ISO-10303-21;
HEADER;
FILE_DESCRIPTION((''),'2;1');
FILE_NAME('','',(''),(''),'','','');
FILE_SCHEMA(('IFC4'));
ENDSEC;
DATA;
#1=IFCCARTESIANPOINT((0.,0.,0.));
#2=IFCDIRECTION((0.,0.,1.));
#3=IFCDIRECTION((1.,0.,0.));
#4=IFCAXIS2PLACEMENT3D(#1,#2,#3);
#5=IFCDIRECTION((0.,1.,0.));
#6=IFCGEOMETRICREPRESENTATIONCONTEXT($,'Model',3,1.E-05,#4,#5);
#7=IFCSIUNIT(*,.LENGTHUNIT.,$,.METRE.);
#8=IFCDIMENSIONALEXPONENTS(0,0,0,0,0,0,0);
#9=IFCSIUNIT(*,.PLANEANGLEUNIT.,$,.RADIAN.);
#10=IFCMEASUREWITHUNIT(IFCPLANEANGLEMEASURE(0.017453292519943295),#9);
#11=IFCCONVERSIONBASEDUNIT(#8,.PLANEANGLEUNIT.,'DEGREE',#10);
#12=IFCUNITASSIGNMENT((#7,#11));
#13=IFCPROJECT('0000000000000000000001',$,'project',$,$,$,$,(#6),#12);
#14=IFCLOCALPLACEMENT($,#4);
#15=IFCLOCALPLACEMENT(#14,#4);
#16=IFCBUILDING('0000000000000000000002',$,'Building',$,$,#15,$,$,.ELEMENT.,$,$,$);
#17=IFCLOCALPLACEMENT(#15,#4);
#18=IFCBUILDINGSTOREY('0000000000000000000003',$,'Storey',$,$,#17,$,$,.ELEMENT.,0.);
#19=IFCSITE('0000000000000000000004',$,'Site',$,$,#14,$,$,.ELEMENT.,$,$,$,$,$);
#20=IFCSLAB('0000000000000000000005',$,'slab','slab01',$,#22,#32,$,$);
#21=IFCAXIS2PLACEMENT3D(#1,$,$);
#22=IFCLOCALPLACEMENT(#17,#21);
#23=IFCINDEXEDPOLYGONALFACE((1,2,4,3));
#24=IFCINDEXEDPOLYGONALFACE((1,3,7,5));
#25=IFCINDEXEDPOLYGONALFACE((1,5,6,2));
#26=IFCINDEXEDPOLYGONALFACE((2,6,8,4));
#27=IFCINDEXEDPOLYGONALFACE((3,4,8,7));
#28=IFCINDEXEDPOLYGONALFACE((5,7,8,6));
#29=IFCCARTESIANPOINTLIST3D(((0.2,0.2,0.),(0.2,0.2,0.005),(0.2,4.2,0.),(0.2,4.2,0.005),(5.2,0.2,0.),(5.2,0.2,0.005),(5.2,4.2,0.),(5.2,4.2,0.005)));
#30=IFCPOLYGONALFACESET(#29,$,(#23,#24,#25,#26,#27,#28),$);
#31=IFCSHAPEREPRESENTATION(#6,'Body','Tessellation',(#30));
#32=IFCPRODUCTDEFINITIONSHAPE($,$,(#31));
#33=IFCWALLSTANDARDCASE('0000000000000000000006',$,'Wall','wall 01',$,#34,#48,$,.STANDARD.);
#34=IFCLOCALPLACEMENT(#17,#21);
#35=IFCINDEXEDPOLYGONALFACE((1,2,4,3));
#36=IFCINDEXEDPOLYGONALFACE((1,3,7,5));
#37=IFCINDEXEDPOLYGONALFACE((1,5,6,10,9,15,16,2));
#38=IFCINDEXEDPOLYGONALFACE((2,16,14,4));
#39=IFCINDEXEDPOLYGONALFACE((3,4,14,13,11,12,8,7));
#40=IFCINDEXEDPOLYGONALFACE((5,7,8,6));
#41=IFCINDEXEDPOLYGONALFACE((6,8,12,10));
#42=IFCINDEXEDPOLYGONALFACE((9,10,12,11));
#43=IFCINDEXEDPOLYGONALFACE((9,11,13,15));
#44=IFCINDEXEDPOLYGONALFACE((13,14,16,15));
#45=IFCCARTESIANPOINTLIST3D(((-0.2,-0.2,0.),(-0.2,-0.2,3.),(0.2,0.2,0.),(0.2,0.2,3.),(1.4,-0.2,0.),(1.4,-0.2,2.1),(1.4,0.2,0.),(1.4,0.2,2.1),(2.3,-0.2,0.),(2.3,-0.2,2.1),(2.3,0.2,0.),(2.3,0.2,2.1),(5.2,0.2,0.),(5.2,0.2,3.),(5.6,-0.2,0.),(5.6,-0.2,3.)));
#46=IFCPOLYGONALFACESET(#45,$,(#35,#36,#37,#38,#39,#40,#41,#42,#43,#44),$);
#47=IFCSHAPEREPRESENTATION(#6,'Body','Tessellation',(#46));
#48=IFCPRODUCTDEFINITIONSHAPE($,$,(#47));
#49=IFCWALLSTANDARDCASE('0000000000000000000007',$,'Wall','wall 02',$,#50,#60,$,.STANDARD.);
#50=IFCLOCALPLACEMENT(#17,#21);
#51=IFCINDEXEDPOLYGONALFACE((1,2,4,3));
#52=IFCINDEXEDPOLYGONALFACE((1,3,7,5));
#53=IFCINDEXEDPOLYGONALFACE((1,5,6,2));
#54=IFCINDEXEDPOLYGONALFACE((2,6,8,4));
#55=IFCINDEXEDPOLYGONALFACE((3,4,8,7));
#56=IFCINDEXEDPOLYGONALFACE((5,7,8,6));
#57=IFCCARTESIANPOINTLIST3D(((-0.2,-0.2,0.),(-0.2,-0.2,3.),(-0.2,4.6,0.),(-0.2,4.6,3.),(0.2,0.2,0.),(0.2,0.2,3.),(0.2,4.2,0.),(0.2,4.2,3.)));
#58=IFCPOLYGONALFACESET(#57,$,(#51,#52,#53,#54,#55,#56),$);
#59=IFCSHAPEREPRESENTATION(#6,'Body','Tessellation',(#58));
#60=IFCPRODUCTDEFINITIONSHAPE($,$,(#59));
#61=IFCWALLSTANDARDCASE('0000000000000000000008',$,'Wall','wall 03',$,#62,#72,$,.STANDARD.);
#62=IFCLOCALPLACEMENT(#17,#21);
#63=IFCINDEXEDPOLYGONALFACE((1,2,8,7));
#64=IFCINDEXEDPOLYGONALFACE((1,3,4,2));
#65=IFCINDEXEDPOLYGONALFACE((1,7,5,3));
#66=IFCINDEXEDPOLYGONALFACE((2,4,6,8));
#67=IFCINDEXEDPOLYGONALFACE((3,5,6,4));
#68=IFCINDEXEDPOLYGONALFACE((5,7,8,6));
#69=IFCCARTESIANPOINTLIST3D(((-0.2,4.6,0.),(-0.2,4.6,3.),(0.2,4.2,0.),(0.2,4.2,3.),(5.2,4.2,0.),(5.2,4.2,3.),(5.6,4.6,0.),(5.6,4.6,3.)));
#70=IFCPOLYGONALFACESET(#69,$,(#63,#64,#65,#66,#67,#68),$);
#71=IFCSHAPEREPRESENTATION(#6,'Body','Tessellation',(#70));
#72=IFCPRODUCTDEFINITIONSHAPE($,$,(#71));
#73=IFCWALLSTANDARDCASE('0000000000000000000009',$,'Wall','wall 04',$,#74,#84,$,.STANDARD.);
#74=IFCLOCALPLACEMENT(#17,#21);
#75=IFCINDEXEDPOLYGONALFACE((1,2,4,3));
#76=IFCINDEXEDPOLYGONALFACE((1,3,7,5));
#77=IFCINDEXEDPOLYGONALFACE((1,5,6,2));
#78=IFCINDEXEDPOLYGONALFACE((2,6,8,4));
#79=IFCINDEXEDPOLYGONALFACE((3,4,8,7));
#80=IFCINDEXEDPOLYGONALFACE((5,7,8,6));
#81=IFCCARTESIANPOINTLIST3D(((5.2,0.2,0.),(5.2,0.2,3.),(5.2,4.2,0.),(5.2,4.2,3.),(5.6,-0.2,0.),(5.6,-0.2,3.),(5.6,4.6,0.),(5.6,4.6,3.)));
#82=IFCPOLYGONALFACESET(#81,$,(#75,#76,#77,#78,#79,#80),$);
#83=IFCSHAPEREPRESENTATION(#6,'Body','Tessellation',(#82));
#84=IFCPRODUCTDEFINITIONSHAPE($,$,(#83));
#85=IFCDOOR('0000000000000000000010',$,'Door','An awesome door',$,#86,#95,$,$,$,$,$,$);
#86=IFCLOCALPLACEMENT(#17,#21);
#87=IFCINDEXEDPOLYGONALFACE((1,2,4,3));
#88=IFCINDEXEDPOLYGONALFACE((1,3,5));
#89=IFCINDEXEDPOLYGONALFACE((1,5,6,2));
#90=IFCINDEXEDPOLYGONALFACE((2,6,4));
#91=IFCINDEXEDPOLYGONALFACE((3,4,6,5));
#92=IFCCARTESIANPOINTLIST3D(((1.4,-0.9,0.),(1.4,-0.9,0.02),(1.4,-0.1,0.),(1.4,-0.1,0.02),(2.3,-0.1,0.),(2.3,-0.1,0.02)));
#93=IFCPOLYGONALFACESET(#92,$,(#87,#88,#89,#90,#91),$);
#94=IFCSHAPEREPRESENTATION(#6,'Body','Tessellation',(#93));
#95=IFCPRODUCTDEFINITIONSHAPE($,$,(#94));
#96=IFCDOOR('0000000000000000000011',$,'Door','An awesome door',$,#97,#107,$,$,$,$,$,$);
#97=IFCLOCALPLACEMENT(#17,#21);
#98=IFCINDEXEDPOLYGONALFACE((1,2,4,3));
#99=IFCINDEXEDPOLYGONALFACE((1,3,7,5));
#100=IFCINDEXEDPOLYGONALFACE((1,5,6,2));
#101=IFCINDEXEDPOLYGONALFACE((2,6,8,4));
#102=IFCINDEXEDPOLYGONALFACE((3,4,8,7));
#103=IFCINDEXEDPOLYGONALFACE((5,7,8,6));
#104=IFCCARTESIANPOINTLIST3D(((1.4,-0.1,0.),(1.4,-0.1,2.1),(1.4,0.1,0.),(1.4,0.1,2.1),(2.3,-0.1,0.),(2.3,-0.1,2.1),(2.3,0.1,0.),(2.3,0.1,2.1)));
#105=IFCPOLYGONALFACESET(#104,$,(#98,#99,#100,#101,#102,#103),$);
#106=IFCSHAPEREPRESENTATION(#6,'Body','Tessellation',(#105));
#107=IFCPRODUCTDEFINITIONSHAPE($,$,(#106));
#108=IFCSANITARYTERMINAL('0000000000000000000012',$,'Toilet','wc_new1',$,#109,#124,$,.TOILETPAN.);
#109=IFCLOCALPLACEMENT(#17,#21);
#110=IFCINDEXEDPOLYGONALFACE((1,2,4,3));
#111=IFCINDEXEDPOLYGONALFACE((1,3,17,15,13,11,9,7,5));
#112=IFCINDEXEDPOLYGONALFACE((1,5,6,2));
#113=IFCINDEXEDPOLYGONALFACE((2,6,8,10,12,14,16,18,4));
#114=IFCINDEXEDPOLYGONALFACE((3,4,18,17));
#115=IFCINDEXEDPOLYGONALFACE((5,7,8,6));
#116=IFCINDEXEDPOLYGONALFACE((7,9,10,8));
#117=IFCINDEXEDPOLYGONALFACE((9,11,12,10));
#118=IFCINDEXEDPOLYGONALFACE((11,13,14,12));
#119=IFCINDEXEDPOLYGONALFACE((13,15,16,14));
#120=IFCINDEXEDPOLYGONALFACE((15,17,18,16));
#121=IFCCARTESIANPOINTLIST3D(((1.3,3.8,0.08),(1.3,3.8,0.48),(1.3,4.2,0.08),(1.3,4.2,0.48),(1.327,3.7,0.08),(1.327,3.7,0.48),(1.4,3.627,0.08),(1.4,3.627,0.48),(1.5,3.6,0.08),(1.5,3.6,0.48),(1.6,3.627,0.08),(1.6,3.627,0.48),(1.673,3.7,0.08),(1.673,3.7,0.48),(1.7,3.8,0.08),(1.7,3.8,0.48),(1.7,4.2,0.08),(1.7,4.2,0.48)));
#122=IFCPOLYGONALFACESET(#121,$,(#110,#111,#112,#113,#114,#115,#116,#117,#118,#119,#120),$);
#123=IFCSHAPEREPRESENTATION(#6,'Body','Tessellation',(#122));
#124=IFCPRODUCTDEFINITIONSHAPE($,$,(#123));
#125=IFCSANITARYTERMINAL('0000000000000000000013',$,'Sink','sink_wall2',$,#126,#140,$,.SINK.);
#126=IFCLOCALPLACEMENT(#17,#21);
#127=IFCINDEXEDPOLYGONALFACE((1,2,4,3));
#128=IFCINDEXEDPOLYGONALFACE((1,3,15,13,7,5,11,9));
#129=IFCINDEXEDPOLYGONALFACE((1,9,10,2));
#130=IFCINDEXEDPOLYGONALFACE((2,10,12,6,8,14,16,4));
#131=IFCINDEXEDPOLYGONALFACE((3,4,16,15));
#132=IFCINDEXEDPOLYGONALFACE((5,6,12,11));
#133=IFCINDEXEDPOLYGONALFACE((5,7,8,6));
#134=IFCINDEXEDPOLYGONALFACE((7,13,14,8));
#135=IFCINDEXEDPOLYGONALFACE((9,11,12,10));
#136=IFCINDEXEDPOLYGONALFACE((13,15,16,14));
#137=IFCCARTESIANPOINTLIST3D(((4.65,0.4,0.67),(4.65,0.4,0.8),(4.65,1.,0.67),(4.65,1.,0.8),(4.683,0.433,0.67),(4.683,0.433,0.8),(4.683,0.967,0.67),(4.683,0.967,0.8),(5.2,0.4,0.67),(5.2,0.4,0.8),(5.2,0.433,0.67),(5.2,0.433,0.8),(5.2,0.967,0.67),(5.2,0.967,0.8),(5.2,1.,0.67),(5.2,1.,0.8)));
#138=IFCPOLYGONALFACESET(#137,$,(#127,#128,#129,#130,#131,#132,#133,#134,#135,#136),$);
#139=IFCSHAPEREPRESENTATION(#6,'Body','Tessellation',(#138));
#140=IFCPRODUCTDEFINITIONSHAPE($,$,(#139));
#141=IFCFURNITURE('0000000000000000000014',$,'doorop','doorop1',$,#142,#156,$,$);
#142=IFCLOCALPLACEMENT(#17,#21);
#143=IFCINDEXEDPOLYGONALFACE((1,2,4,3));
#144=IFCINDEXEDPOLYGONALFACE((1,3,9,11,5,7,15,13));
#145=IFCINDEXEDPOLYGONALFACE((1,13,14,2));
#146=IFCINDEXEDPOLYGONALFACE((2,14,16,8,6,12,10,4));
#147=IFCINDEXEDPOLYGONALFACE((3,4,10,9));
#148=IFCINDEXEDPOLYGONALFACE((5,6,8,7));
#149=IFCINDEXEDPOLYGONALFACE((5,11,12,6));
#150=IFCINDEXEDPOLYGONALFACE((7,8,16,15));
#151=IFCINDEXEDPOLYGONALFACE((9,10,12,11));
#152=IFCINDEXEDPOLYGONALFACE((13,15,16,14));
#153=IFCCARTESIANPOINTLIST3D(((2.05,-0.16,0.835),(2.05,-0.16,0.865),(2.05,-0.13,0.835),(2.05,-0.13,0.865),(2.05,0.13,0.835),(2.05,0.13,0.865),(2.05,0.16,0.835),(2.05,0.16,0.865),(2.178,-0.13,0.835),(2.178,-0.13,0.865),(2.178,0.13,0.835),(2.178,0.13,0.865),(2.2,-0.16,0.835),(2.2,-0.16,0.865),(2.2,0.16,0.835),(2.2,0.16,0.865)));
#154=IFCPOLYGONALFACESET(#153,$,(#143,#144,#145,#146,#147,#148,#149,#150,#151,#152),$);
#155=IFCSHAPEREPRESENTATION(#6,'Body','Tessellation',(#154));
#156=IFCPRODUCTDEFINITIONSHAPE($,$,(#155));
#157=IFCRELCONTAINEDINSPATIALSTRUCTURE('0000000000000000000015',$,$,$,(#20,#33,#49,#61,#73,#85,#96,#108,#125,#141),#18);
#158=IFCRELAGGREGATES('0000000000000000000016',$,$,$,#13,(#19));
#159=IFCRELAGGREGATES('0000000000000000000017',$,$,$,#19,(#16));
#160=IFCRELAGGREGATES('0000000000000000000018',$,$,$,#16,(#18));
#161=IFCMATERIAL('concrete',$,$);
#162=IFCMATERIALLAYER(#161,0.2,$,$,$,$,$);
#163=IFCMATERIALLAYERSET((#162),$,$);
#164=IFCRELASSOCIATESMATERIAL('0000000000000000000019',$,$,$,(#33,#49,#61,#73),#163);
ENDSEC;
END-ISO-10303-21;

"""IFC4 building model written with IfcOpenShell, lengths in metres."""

from ifc_helpers import new_model, entity, si_unit, converted_unit, direction, frame, origin_with_axes, place, context, project, spatial, polyline, outline, extrude, material, layer, layer_set, layer_usage, element, save


model = new_model("IFC4")

# Units and contexts
model_context = context("Model", 3, precision=1e-05, world=origin_with_axes(), true_north=direction((0.0, 1.0, 0.0)))
ifc_project = project(units=[si_unit("LENGTHUNIT", "METRE"), converted_unit("PLANEANGLEUNIT", "DEGREE", entity("IfcPlaneAngleMeasure", 0.017453292519943295), si_unit("PLANEANGLEUNIT", "RADIAN"), dimensions=[0, 0, 0, 0, 0, 0, 0])], contexts=[model_context])

# Site, building, storey
site_placement = place(None, origin_with_axes())
site = spatial("IfcSite", under=ifc_project, at=site_placement, Name="Site", CompositionType="ELEMENT")
building_placement = place(site_placement, origin_with_axes())
building = spatial("IfcBuilding", under=site, at=building_placement, Name="Building", CompositionType="ELEMENT")
storey_placement = place(building_placement, origin_with_axes())
storey = spatial("IfcBuildingStorey", under=building, at=storey_placement, Name="Storey", CompositionType="ELEMENT", Elevation=0.0)

# Slab
slab_placement = place(storey_placement, origin_with_axes())
element("IfcSlab", 1, at=slab_placement, inside=storey, Name="slab", Description="slab01", context=model_context, shape_type="SweptSolid", body=[
    extrude(outline(polyline([(0.2, 0.2), (0.2, 4.2), (5.2, 4.2), (5.2, 0.2)])), origin_with_axes(), (0.0, 0.0, 1.0), 0.005),
])

# Wall, opening
ifc_material = material(Name="concrete")
ifc_layer = layer(ifc_material, 0.2)
ifc_layer_set = layer_set([ifc_layer])
ifc_layer_usage = layer_usage(ifc_layer_set, "AXIS2", "POSITIVE", -0.1)
placement_1 = place(storey_placement, origin_with_axes())
wall_1 = element("IfcWallStandardCase", 2, at=placement_1, inside=storey, material=ifc_layer_usage, Name="Wall", Description="wall 01", PredefinedType="STANDARD", context=model_context, shape_type="SweptSolid", body=[
    extrude(outline(polyline([(-0.2, -0.2), (5.6, -0.2), (5.2, 0.2), (0.2, 0.2), (-0.2, -0.2)])), origin_with_axes(), (0.0, 0.0, 1.0), 3.0),
])
opening_placement = place(placement_1, origin_with_axes())
element("IfcOpeningElement", 3, at=opening_placement, cuts=wall_1, context=model_context, shape_type="SweptSolid", body=[
    extrude(outline(polyline([(1.4, 0.2), (1.4, -0.2), (2.3, -0.2), (2.3, 0.2)])), origin_with_axes(), (0.0, 0.0, 1.0), 2.1),
])

# Walls
element("IfcWallStandardCase", 4, at=placement_1, inside=storey, material=ifc_layer_usage, Name="Wall", Description="wall 02", PredefinedType="STANDARD", context=model_context, shape_type="SweptSolid", body=[
    extrude(outline(polyline([(0.2, 0.2), (0.2, 4.2), (-0.2, 4.6), (-0.2, -0.2), (0.2, 0.2)])), origin_with_axes(), (0.0, 0.0, 1.0), 3.0),
])
element("IfcWallStandardCase", 5, at=placement_1, inside=storey, material=ifc_layer_usage, Name="Wall", Description="wall 03", PredefinedType="STANDARD", context=model_context, shape_type="SweptSolid", body=[
    extrude(outline(polyline([(-0.2, 4.6), (0.2, 4.2), (5.2, 4.2), (5.6, 4.6), (-0.2, 4.6)])), origin_with_axes(), (0.0, 0.0, 1.0), 3.0),
])
element("IfcWallStandardCase", 6, at=placement_1, inside=storey, material=ifc_layer_usage, Name="Wall", Description="wall 04", PredefinedType="STANDARD", context=model_context, shape_type="SweptSolid", body=[
    extrude(outline(polyline([(5.6, -0.2), (5.2, 0.2), (5.2, 4.2), (5.6, 4.6), (5.6, -0.2)])), origin_with_axes(), (0.0, 0.0, 1.0), 3.0),
])

# Doors
placement_2 = place(opening_placement, origin_with_axes())
element("IfcDoor", 7, at=placement_2, inside=storey, Name="Door", Description="An awesome door", context=model_context, shape_type="Curve", body=[
    extrude(outline(polyline([(1.4, -0.1), (1.4, -0.9), (2.3, -0.1)])), origin_with_axes(), (0.0, 0.0, 1.0), 0.02),
])
element("IfcDoor", 8, at=placement_2, inside=storey, Name="Door", Description="An awesome door", context=model_context, shape_type="SweptSolid", body=[
    extrude(outline(polyline([(1.4, 0.1), (1.4, -0.1), (2.3, -0.1), (2.3, 0.1), (1.4, 0.1)])), origin_with_axes(), (0.0, 0.0, 1.0), 2.1),
])

# Sanitary terminals
placement_3 = place(placement_1, origin_with_axes())
element("IfcSanitaryTerminal", 9, at=placement_3, inside=storey, Name="Toilet", Description="wc_new1", PredefinedType="TOILETPAN", context=model_context, shape_type="SweptSolid", body=[
    extrude(outline(polyline([(-0.2, 0.2), (0.2, 0.2), (0.2, -0.2), (0.173, -0.3), (0.1, -0.373), (0.0, -0.4), (-0.1, -0.373), (-0.173, -0.3), (-0.2, -0.2), (-0.2, 0.2)])), frame((1.5, 4.0, 0.08), z_axis=(0.0, 0.0, 1.0), x_axis=(1.0, 0.0, 0.0)), (0.0, 0.0, 1.0), 0.4),
])
placement_4 = place(placement_1, origin_with_axes())
element("IfcSanitaryTerminal", 10, at=placement_4, inside=storey, Name="Sink", Description="sink_wall2", PredefinedType="SINK", context=model_context, shape_type="SweptSolid", body=[
    extrude(outline(polyline([(-0.275, -0.3), (-0.275, 0.3), (0.275, 0.3), (0.275, 0.267), (-0.242, 0.267), (-0.242, -0.267), (0.275, -0.267), (0.275, -0.3), (-0.275, -0.3)])), frame((4.925, 0.7, 0.67), z_axis=(0.0, 0.0, 1.0), x_axis=(1.0, 0.0, 0.0)), (0.0, 0.0, 1.0), 0.13),
])

# Furniture
furniture_1_placement = place(placement_1, origin_with_axes())
element("IfcFurniture", 11, at=furniture_1_placement, inside=storey, Name="doorop", Description="doorop1", context=model_context, shape_type="SweptSolid", body=[
    extrude(outline(polyline([(2.05, 0.16), (2.2, 0.16), (2.2, -0.16), (2.05, -0.16), (2.05, -0.13), (2.178, -0.13), (2.178, 0.13), (2.05, 0.13)])), frame((0.0, 0.0, 0.835), z_axis=(0.0, 0.0, 1.0), x_axis=(1.0, 0.0, 0.0)), (0.0, 0.0, 1.0), 0.03),
])

save(model, "model.ifc")
